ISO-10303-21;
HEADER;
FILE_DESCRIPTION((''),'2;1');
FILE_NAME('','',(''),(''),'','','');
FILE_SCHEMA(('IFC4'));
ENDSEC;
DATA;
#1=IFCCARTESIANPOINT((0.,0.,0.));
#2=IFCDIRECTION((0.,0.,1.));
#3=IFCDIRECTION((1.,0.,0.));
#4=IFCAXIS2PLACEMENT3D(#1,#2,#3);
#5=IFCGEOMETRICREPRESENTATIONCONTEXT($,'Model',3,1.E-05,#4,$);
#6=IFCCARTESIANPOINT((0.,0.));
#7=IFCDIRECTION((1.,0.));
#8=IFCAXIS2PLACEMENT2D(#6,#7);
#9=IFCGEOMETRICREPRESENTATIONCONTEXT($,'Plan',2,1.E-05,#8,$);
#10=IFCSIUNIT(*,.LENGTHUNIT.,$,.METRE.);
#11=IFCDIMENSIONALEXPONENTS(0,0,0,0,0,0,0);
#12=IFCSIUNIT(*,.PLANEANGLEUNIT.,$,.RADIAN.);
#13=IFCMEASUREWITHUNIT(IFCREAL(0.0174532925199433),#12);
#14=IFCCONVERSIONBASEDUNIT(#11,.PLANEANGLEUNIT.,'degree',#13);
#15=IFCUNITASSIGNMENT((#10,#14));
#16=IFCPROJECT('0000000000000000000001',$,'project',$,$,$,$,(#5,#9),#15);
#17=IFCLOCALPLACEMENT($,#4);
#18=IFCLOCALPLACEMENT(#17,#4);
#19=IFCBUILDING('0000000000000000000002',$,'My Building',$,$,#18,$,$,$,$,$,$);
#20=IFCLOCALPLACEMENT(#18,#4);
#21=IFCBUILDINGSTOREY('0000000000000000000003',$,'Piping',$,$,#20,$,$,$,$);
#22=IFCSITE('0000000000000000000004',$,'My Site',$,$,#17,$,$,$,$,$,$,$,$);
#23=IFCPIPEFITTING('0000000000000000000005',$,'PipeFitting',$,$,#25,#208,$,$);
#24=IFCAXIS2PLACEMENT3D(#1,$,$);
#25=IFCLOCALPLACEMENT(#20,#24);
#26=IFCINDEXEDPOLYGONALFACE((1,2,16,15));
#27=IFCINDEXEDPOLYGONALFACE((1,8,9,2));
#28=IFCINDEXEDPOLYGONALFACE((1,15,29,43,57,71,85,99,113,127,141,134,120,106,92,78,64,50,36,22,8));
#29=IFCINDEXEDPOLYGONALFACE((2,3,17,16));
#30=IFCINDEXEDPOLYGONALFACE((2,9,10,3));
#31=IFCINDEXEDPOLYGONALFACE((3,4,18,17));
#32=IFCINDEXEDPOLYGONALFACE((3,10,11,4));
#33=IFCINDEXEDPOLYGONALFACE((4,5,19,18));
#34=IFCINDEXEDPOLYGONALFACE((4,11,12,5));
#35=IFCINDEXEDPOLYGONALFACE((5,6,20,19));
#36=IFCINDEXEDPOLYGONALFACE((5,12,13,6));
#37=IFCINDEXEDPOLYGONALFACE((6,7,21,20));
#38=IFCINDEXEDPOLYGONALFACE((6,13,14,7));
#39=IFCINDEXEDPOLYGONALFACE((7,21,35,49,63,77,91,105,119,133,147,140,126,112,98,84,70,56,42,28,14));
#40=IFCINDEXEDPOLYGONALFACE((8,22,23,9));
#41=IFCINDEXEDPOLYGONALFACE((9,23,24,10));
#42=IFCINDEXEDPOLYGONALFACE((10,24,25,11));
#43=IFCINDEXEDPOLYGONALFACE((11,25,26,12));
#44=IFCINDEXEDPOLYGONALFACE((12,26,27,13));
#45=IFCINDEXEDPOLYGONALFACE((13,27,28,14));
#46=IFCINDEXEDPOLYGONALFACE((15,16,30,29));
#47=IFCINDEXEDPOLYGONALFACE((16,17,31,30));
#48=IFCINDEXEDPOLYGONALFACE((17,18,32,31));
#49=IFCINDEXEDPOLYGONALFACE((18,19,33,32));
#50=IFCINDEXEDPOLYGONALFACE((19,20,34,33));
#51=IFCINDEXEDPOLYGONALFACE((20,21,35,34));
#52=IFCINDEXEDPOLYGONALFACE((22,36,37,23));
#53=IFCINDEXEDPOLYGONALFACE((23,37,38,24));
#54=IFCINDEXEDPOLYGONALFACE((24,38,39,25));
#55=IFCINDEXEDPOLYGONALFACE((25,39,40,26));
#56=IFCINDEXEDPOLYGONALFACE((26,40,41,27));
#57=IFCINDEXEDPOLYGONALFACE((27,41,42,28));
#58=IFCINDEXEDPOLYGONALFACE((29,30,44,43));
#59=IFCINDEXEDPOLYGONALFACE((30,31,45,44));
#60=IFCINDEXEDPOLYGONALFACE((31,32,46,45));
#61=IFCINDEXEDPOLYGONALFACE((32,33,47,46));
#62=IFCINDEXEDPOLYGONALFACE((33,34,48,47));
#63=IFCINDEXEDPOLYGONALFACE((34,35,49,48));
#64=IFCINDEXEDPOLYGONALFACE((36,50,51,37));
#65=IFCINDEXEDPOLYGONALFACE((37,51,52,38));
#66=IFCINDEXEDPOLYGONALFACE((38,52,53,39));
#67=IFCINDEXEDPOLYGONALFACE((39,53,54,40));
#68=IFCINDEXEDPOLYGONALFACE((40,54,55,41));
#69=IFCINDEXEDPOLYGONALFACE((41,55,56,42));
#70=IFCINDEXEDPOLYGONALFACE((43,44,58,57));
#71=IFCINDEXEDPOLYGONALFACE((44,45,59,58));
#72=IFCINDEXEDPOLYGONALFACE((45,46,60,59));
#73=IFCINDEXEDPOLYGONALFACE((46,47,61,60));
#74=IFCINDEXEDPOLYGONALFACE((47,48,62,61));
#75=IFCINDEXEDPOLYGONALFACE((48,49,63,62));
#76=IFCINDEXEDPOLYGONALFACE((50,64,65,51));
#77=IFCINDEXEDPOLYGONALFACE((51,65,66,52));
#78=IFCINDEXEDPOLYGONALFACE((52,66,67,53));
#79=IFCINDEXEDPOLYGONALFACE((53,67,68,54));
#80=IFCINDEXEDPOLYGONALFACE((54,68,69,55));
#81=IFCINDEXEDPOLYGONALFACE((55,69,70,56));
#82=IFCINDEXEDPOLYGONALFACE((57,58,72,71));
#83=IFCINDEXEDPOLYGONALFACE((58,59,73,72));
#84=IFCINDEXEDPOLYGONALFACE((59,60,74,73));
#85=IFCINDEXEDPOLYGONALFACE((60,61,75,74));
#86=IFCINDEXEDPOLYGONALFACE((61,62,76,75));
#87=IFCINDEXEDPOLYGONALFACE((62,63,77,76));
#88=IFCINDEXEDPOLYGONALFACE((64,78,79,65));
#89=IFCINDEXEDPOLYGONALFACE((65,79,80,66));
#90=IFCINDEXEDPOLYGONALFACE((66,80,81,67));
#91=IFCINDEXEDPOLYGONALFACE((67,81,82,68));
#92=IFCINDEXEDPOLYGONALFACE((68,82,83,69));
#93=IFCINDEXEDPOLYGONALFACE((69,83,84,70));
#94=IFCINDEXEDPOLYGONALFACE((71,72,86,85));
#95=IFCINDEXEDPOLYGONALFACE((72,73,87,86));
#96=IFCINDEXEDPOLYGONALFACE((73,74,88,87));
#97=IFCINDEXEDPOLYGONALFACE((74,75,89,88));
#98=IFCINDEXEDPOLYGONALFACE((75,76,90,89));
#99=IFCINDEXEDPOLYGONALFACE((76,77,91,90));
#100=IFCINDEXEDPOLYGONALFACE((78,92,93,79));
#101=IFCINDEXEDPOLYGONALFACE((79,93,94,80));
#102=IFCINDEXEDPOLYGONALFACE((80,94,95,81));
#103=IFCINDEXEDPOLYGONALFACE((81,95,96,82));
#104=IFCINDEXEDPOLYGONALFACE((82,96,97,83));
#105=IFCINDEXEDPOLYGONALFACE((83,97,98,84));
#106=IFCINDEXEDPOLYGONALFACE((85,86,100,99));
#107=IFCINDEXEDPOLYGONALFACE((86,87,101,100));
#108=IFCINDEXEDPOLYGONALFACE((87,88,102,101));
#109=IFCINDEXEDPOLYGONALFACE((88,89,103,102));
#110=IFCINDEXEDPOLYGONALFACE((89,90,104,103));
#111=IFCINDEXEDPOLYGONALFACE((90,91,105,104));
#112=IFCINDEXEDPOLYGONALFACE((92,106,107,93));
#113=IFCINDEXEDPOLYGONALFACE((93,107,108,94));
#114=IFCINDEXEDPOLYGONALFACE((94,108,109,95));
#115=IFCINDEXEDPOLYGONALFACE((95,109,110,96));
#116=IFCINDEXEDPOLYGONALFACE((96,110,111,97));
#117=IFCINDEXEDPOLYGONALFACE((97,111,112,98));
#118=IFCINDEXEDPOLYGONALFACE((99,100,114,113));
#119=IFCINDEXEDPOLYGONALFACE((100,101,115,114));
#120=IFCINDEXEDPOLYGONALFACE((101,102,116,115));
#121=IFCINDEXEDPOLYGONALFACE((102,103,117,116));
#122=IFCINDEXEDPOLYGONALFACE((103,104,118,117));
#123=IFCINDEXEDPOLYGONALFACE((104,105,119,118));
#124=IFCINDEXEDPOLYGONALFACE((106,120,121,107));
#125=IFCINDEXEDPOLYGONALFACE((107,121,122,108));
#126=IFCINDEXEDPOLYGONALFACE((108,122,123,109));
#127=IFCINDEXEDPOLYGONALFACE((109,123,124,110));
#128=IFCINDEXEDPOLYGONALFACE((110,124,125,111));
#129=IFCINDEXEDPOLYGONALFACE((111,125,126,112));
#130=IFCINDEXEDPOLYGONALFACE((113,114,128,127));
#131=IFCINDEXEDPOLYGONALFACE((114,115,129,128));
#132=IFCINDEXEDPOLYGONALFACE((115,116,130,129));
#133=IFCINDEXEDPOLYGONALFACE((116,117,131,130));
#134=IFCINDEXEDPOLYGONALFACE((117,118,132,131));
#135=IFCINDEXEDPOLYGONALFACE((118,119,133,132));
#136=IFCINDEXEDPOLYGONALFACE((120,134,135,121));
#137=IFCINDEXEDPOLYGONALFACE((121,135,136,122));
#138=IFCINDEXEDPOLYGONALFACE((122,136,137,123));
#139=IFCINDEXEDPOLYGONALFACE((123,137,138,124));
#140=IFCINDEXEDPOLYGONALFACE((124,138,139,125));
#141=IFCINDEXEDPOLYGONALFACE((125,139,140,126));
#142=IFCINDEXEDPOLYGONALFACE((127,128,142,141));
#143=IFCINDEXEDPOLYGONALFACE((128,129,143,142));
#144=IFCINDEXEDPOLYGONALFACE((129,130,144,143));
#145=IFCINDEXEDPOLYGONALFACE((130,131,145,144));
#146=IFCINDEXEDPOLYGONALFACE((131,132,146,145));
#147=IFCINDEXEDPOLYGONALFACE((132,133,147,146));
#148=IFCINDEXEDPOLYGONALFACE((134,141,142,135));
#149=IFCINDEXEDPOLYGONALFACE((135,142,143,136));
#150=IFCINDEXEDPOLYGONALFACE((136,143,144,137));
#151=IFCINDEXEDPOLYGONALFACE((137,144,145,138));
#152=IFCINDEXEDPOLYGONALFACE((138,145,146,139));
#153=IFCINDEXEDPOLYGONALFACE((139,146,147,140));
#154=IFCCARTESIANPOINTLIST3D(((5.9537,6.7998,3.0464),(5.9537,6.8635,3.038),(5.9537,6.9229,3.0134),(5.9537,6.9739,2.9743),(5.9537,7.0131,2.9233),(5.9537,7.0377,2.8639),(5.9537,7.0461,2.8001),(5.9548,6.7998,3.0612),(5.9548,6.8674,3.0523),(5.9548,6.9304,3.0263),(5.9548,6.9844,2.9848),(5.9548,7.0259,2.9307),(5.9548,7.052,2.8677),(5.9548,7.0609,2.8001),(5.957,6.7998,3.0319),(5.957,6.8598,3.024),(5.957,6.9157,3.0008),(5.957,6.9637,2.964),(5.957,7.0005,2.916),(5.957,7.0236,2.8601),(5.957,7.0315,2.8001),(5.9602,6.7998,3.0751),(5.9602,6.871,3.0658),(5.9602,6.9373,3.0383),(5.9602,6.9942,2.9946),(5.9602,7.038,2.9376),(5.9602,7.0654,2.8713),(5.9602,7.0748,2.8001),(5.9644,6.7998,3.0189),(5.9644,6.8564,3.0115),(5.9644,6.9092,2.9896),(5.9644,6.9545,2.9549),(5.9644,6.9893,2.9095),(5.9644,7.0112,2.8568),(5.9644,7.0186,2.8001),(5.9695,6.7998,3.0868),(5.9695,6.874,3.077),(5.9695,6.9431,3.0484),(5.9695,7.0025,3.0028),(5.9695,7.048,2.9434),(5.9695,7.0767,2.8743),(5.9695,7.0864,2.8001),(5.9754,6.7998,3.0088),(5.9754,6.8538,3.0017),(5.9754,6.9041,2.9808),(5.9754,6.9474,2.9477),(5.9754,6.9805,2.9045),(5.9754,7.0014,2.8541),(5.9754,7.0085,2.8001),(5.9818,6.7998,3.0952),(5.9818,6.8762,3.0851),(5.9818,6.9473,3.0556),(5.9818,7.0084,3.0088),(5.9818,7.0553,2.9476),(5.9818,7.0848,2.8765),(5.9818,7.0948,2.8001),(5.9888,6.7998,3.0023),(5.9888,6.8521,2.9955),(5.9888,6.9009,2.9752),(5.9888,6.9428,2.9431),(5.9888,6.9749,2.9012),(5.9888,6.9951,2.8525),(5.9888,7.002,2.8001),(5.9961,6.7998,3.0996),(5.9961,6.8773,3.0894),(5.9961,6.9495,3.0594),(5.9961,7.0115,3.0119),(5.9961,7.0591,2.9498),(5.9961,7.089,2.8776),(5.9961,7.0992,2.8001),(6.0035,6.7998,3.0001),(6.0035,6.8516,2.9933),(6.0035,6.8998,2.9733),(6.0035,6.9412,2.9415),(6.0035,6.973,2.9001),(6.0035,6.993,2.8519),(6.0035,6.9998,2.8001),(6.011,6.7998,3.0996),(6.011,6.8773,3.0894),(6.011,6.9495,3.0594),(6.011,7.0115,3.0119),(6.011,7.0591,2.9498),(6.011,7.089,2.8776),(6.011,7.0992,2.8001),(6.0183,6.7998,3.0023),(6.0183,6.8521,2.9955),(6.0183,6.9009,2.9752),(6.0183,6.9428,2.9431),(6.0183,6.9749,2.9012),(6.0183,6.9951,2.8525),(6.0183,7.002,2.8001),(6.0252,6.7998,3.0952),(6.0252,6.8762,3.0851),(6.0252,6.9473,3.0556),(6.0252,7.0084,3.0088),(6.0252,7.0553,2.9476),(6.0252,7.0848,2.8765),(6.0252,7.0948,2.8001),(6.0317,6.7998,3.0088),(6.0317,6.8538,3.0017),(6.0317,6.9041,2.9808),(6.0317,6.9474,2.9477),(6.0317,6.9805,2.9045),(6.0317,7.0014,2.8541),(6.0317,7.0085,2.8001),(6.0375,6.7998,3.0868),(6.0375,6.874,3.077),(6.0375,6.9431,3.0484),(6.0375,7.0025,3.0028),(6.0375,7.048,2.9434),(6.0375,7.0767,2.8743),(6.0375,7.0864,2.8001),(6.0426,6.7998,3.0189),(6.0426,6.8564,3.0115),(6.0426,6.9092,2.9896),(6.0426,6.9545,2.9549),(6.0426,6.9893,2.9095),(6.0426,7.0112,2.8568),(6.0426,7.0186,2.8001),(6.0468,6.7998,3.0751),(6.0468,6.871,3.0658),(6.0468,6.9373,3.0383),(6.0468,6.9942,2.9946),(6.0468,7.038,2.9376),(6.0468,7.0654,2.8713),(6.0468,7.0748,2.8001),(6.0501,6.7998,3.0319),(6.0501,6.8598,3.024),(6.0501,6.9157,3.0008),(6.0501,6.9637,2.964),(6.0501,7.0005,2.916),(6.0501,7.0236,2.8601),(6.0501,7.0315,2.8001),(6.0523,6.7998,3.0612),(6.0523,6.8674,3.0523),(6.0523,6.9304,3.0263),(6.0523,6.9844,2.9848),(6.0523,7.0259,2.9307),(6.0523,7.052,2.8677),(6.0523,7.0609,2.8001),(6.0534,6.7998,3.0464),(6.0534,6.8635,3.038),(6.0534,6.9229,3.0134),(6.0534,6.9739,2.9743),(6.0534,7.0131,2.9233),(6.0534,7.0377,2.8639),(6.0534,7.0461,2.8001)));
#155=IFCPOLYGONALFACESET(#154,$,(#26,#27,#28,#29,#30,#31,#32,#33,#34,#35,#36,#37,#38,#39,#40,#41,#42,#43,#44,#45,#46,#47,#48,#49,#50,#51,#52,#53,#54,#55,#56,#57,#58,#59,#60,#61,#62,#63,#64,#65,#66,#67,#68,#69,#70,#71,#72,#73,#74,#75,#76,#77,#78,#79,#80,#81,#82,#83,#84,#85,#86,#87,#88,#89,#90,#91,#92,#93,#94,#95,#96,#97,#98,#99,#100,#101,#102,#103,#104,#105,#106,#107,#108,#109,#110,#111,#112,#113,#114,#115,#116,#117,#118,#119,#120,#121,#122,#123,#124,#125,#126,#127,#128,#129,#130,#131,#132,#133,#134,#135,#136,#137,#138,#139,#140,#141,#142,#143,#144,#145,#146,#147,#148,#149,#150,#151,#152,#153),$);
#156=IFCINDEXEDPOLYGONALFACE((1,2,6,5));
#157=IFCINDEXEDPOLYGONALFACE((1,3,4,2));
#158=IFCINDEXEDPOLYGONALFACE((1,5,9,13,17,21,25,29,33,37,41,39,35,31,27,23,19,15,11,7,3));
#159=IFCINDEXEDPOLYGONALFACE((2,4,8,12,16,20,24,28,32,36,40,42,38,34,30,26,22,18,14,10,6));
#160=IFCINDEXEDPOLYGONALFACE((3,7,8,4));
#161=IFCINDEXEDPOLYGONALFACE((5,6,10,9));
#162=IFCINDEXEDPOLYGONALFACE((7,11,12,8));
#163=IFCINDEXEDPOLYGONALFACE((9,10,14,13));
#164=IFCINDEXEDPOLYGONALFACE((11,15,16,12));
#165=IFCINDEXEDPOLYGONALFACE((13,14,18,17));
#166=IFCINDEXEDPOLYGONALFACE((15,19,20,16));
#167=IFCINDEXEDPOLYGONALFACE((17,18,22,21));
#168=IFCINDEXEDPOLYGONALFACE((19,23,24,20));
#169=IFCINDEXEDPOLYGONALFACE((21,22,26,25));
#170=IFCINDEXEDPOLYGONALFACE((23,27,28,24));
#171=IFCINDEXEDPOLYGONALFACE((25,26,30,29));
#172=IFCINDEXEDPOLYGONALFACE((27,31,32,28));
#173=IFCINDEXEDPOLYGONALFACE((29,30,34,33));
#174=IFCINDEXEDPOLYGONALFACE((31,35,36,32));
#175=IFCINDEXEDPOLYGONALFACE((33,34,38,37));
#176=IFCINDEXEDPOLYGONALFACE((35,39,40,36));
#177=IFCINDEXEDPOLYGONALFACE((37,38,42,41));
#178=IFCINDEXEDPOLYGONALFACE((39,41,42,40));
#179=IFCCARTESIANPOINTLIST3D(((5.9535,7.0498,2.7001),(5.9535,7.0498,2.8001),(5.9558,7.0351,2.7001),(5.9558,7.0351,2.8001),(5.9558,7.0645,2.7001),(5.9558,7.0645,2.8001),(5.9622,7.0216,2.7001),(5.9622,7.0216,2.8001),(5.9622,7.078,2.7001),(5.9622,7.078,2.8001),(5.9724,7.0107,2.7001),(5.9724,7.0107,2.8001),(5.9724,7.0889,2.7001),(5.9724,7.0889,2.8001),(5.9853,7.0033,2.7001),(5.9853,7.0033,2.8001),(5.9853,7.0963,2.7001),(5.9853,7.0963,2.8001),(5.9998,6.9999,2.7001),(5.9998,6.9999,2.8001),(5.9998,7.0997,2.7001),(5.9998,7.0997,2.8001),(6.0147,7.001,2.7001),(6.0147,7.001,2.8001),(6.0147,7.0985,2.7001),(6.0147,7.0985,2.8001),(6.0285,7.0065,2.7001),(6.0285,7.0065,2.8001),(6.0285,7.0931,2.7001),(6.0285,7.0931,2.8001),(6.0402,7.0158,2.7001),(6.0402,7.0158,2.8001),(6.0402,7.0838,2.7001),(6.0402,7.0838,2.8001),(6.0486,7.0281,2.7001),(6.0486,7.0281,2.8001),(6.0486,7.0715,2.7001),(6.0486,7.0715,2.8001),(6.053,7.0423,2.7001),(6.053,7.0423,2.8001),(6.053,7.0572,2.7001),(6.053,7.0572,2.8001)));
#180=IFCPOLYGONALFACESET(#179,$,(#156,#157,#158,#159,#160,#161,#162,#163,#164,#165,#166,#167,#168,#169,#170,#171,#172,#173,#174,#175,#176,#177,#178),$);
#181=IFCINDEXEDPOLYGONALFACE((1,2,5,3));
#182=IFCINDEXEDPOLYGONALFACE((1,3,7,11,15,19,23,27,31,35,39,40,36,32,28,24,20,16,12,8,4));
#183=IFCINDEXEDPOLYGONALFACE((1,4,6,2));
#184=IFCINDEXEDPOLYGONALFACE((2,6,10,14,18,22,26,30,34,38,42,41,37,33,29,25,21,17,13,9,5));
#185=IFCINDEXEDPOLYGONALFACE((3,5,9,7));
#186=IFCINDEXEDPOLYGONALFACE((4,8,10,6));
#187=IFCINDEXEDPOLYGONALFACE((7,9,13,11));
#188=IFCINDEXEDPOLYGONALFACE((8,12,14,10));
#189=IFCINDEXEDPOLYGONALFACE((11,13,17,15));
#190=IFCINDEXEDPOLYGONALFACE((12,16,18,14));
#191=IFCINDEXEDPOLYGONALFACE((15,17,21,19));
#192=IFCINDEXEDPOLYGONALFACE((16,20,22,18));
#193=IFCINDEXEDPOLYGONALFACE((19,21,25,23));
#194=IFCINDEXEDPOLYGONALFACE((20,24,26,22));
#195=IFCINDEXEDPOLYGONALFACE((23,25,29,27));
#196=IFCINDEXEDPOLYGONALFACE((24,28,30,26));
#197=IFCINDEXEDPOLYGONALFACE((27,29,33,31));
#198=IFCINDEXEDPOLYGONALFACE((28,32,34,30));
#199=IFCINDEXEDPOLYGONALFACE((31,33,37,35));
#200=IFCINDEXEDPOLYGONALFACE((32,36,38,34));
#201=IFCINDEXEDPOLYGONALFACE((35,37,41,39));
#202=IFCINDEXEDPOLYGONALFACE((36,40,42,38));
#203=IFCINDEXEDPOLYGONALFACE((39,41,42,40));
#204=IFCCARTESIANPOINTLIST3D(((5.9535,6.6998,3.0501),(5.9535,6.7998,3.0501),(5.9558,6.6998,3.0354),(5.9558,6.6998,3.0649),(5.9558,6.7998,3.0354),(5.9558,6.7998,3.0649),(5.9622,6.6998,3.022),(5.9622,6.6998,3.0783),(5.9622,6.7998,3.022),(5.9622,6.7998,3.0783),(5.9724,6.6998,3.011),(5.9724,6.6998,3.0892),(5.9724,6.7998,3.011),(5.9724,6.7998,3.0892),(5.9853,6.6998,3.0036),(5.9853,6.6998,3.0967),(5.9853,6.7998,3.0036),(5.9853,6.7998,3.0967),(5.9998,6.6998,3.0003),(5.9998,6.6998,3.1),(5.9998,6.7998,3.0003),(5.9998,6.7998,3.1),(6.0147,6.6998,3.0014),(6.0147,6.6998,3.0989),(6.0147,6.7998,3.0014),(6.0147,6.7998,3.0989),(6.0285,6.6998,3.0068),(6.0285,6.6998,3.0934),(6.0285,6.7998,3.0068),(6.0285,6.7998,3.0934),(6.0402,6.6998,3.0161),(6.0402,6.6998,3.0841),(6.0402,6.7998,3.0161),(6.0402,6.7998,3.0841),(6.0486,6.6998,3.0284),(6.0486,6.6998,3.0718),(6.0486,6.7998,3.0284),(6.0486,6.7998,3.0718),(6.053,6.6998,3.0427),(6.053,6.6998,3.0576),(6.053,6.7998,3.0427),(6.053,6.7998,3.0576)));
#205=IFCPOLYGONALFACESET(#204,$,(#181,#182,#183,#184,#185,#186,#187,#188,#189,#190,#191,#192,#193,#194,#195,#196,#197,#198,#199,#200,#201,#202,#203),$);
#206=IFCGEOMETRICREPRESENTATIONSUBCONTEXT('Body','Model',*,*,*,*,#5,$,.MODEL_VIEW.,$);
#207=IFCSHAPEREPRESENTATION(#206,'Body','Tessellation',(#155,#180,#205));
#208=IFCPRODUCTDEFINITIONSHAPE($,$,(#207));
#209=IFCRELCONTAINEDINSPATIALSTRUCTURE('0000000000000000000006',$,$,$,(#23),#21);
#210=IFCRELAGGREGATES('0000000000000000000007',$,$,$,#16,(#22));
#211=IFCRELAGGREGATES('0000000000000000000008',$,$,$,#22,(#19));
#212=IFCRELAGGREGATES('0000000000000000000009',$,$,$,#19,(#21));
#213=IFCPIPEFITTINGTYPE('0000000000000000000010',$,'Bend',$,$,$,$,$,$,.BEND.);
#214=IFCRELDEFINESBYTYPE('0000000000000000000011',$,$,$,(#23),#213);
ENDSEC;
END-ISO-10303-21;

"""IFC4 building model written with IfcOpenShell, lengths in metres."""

from ifc_helpers import new_model, entity, si_unit, converted_unit, frame, origin_with_axes, origin_2d_with_axis, place, context, subcontext, project, spatial, circle, extrude, source, transform, mapped, type_object, type_shapes, element, save


model = new_model("IFC4")

# Units and contexts
model_context = context("Model", 3, precision=1e-05, world=origin_with_axes())
plan_context = context("Plan", 2, precision=1e-05, world=origin_2d_with_axis())
body_context = subcontext(model_context, "Body", "Model", "MODEL_VIEW")
ifc_project = project(units=[si_unit("LENGTHUNIT", "METRE"), converted_unit("PLANEANGLEUNIT", "degree", entity("IfcReal", 0.0174532925199433), si_unit("PLANEANGLEUNIT", "RADIAN"), dimensions=[0, 0, 0, 0, 0, 0, 0])], contexts=[model_context, plan_context])

# Site, building, storey
site_placement = place(None, origin_with_axes())
site = spatial("IfcSite", under=ifc_project, at=site_placement, Name="My Site")
building_placement = place(site_placement, origin_with_axes())
building = spatial("IfcBuilding", under=site, at=building_placement, Name="My Building")
storey_placement = place(building_placement, origin_with_axes())
storey = spatial("IfcBuildingStorey", under=building, at=storey_placement, Name="Piping")

# Pipe fitting
pipe_fitting_type_1 = type_object("IfcPipeFittingType", Name="Bend", PredefinedType="BEND")
shared_shape = source(origin_with_axes(), body_context, "Body", "SolidModel", [
    entity("IfcSweptDiskSolid", entity("IfcIndexedPolyCurve", entity("IfcCartesianPointList3D", [[0.0, 0.0, -0.1], [0.0, -0.0732, -0.2768], [0.0, -0.25, -0.35]]), [entity("IfcArcIndex", [1, 2, 3])]), 0.05),
    extrude(circle(Radius=0.05), origin_with_axes(), (0.0, 0.0, -1.0), 0.1),
    extrude(circle(Radius=0.05), frame((0.0, -0.25, -0.35), z_axis=(0.0, -1.0, 0.0), x_axis=(1.0, 0.0, 0.0)), (0.0, 0.0, 1.0), 0.1),
])
type_shapes(pipe_fitting_type_1, [shared_shape])
for number, where, z_axis, x_axis, name in (
    (1, (6.0035, 7.0498, 2.7001), (0.0, 0.0, -1.0), (-1.0, 0.0, 0.0), "PipeFitting"),
):
    element("IfcPipeFitting", number, at=place(storey_placement, frame(where, z_axis=z_axis, x_axis=x_axis)), inside=storey, type_object=pipe_fitting_type_1, Name=name, context=body_context, shape_type="MappedRepresentation", body=[
        mapped(shared_shape, transform((0.0, 0.0, 0.0), x_axis=(1.0, 0.0, 0.0), y_axis=(0.0, 1.0, 0.0), z_axis=(0.0, 0.0, 1.0), scale=1.0)),
    ])

save(model, "model.ifc")
